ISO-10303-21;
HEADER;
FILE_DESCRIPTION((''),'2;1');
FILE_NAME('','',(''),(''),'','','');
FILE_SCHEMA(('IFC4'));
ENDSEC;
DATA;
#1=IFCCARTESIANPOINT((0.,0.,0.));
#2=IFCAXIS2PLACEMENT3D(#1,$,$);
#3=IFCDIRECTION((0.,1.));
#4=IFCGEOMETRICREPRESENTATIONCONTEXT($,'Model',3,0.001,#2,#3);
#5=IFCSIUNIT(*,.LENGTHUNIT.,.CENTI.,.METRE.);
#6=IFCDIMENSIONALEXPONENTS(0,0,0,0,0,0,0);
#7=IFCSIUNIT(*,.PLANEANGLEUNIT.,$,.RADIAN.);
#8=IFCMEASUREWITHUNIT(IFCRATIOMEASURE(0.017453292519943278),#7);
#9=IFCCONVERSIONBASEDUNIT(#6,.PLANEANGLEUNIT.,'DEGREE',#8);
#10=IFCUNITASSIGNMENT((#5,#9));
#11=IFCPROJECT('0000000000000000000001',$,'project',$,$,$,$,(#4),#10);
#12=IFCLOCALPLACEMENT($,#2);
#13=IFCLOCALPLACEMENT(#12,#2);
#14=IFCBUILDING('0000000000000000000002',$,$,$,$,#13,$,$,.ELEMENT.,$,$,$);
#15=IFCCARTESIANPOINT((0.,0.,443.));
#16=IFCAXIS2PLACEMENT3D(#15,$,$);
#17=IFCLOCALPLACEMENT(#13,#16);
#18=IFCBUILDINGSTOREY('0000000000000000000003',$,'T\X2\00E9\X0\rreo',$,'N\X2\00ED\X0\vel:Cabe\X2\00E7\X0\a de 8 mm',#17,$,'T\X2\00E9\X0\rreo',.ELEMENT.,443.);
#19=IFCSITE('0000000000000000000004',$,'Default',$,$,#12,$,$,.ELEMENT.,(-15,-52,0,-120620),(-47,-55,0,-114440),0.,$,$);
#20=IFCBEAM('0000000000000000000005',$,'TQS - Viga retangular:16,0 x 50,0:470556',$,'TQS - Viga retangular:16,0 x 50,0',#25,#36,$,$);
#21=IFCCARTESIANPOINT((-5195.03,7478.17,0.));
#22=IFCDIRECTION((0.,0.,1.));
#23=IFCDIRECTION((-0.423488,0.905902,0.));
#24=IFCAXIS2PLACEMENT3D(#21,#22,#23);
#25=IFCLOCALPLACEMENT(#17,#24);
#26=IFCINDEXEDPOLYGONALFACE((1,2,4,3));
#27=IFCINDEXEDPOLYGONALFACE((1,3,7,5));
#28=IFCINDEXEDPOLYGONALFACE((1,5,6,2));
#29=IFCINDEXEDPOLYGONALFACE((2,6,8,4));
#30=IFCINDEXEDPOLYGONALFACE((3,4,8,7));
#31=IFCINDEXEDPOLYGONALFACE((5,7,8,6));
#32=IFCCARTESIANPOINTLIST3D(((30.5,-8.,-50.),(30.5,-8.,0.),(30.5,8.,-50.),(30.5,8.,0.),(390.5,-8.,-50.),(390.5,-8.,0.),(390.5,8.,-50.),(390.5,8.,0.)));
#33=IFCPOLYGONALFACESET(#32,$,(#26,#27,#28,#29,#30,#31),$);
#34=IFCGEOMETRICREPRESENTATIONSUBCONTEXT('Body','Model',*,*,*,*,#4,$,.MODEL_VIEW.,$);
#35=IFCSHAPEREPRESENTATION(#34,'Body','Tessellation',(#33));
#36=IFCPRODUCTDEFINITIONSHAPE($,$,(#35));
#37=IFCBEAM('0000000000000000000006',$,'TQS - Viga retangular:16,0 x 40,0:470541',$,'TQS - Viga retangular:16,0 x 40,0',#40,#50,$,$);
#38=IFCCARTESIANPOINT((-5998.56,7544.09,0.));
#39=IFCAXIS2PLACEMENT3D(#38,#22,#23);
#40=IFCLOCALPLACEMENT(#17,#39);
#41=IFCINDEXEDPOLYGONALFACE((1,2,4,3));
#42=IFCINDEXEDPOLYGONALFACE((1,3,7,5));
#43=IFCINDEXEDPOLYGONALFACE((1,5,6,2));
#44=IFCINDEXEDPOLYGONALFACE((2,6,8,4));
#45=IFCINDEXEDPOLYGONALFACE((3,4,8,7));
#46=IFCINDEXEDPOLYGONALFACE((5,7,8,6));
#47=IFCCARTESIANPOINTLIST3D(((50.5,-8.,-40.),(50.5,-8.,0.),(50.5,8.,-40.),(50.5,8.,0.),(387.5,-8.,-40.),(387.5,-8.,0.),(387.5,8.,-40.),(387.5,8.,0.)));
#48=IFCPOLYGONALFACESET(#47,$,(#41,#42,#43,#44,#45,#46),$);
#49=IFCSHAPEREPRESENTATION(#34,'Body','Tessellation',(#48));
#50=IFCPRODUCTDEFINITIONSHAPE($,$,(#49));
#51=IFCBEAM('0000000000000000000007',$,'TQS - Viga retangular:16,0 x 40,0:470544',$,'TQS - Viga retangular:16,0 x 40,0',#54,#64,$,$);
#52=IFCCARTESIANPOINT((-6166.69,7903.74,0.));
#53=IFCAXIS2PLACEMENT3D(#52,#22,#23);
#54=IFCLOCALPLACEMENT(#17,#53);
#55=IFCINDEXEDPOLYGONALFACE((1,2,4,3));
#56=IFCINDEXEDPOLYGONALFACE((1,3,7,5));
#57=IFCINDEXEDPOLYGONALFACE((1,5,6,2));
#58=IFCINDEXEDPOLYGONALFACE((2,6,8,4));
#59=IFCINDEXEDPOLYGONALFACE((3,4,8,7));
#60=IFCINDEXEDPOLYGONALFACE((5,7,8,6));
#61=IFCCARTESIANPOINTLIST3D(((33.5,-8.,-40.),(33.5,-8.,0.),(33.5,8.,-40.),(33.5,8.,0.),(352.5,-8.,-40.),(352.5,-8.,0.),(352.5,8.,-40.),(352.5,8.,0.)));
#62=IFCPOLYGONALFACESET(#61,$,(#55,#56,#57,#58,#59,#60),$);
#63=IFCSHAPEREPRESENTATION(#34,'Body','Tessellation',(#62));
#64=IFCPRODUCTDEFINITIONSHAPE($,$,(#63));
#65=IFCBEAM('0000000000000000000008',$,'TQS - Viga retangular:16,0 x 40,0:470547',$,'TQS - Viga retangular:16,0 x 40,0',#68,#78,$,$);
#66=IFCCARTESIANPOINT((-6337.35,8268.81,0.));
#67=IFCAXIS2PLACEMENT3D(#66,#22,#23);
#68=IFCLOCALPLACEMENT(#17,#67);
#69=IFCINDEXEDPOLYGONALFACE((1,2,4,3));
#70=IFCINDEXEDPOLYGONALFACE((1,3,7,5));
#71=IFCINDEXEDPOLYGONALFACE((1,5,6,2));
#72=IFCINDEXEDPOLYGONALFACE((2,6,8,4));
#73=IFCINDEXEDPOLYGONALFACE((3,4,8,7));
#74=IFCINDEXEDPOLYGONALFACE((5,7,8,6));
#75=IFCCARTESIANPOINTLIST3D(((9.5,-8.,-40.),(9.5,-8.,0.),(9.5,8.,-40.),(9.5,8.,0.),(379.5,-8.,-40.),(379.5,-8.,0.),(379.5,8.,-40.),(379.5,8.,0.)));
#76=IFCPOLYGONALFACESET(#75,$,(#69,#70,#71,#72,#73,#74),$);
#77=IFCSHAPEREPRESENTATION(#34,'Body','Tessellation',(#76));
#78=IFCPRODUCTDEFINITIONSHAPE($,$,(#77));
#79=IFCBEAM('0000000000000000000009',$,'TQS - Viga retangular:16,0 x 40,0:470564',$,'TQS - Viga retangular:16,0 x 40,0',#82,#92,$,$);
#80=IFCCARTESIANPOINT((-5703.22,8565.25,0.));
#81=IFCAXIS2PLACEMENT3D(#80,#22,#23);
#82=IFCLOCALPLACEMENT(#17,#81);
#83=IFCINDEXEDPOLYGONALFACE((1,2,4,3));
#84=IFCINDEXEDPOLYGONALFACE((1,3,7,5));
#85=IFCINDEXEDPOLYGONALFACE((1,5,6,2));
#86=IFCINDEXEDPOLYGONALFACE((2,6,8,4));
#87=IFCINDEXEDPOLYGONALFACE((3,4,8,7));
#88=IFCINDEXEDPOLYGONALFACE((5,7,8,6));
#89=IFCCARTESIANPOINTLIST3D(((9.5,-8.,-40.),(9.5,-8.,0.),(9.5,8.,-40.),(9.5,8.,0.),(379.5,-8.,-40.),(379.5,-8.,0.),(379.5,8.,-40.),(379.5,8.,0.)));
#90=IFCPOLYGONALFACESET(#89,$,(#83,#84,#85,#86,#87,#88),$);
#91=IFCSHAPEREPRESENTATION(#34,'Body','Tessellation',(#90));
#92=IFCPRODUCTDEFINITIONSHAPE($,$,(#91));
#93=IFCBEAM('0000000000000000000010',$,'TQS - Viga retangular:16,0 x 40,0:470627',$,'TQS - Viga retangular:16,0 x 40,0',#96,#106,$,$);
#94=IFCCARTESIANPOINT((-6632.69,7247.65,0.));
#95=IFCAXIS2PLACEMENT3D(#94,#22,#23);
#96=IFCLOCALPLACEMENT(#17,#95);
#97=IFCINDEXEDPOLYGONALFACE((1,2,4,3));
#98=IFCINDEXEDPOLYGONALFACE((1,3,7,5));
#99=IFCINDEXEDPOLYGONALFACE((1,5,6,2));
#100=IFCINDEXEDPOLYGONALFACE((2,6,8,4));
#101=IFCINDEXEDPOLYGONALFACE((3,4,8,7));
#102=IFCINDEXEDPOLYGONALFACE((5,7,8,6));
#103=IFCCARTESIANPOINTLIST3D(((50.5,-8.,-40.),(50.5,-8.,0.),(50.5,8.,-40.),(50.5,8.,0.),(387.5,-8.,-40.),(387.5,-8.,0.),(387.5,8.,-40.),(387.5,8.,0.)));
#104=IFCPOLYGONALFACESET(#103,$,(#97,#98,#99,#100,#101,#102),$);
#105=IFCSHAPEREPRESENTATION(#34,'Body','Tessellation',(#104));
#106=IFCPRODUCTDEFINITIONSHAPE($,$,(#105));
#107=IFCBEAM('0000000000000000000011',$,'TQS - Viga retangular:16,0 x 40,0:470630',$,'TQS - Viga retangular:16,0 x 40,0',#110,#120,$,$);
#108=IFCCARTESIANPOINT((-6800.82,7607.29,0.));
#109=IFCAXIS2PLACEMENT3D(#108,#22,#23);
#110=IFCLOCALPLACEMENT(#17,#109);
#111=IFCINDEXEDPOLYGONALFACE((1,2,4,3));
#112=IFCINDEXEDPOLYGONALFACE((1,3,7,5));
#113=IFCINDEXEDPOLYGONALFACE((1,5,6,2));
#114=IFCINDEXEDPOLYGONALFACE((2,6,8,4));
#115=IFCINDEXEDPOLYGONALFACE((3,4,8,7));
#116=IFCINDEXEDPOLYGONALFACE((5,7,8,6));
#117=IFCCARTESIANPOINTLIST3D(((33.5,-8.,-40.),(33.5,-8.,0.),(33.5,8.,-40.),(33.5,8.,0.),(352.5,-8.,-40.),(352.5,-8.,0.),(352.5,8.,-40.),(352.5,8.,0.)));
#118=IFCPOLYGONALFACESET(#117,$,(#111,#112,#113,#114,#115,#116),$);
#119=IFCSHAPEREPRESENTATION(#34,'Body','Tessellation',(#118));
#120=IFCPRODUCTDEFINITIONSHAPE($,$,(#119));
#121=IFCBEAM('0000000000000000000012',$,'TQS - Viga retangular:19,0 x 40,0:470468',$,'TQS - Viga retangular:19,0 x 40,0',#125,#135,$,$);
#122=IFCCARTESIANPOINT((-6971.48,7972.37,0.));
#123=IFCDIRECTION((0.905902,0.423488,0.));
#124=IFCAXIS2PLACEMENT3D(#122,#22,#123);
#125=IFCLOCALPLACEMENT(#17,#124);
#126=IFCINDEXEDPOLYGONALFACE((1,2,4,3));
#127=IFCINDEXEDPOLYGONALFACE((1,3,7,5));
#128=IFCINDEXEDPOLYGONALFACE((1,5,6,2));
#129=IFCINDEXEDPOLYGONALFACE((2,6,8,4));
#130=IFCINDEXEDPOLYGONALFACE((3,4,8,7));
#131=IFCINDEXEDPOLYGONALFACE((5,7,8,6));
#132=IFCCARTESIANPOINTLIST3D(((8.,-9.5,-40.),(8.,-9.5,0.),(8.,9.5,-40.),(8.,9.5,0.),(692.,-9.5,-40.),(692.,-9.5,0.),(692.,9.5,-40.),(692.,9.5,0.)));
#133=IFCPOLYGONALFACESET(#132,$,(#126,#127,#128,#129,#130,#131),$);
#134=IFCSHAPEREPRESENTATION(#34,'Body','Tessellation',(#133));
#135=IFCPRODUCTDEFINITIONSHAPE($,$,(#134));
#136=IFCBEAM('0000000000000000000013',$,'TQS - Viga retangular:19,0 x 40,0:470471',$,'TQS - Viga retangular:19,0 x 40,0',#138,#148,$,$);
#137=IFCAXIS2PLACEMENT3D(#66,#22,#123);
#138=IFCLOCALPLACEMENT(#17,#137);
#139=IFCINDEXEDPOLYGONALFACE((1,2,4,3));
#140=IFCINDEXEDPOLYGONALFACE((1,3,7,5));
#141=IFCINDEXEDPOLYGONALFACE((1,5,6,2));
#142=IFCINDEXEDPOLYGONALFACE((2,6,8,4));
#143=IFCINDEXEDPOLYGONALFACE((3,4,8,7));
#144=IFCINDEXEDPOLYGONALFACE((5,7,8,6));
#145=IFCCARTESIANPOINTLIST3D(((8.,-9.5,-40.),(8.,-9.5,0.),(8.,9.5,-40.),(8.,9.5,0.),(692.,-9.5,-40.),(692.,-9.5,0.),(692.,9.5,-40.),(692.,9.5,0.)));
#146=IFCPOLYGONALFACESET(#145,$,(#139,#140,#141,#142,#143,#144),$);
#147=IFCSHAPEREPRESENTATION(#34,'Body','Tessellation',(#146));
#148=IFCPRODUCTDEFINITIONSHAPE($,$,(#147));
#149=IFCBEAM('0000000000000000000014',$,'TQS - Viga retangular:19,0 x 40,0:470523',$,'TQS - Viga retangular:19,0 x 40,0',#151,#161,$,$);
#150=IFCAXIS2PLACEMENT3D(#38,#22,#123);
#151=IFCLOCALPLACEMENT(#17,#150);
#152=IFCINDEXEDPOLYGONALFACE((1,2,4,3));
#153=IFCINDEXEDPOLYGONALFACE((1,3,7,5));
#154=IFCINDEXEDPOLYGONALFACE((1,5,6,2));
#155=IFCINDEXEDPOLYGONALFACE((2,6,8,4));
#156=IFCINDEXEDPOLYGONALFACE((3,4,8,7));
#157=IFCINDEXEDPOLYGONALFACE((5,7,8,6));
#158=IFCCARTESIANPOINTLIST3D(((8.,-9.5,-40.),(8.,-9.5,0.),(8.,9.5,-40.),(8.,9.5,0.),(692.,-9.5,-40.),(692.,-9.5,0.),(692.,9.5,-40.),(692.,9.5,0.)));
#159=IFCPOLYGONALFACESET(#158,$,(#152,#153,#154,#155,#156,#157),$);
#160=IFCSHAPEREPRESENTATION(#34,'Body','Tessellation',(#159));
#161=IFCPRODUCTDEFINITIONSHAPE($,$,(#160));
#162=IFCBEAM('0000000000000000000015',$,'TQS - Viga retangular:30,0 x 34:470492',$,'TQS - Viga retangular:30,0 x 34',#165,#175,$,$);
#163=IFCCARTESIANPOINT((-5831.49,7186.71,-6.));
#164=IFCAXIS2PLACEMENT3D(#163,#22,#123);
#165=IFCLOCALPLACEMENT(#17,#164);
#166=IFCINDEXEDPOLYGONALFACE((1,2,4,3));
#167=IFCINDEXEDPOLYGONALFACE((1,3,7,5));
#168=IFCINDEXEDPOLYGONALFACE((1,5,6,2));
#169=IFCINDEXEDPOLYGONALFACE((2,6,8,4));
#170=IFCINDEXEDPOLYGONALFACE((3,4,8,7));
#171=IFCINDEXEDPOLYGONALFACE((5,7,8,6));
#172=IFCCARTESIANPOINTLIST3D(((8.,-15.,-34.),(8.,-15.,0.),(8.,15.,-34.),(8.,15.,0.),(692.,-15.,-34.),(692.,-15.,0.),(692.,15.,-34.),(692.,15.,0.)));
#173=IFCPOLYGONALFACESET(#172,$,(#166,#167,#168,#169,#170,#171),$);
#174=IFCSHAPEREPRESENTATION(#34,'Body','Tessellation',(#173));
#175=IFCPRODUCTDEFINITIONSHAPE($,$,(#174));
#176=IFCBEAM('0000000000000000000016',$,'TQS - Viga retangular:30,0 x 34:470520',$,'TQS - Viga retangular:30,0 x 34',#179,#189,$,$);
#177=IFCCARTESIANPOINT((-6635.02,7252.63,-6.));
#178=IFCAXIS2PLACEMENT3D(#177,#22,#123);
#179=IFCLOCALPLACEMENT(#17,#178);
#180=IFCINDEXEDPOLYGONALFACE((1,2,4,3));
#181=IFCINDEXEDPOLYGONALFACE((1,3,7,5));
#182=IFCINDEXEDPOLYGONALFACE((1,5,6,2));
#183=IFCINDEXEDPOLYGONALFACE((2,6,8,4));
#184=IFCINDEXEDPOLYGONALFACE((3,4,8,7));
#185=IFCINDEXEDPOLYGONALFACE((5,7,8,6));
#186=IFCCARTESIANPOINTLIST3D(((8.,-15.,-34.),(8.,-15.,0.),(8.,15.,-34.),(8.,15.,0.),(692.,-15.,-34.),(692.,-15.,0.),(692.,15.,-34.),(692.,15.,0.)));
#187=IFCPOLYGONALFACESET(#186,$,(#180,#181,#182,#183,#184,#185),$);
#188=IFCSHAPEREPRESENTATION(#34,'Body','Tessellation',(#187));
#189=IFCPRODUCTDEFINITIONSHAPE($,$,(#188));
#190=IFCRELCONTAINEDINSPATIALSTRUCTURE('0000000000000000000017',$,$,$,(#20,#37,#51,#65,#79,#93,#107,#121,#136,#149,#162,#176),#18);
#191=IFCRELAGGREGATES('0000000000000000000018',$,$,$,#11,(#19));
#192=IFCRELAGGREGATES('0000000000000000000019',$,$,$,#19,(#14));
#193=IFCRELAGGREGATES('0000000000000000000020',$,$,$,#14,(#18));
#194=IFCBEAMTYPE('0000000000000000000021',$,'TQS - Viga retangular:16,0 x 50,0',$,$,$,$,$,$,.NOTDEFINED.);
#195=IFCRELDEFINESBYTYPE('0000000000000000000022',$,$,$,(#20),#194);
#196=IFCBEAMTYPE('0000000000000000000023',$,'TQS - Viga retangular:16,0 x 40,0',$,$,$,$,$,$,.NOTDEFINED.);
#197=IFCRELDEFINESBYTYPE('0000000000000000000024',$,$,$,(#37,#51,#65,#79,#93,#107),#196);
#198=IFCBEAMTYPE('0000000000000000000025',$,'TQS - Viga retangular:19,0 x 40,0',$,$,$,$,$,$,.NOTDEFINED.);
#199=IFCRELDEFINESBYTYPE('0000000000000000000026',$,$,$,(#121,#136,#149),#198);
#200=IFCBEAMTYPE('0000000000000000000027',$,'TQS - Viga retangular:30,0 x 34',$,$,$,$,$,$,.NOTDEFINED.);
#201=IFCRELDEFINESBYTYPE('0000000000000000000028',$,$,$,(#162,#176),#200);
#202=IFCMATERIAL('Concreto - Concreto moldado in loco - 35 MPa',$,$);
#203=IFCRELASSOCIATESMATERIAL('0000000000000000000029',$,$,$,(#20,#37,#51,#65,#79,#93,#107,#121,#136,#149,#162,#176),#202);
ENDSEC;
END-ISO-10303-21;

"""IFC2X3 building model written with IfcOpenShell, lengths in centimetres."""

from ifc_helpers import new_model, entity, si_unit, converted_unit, direction, frame, frame_2d, origin, origin_2d_with_axis, place, context, subcontext, project, spatial, rectangle, extrude, material, type_object, element, save


model = new_model("IFC2X3")

# Units and contexts
model_context = context("Model", 3, precision=0.001, world=origin(), true_north=direction((0.0, 1.0)))
body_context = subcontext(model_context, "Body", "Model", "MODEL_VIEW")
ifc_project = project(units=[si_unit("LENGTHUNIT", "METRE", prefix="CENTI"), converted_unit("PLANEANGLEUNIT", "DEGREE", entity("IfcRatioMeasure", 0.017453292519943278), si_unit("PLANEANGLEUNIT", "RADIAN"), dimensions=[0, 0, 0, 0, 0, 0, 0])], contexts=[model_context])

# Site, building, storey
site_placement = place(None, origin())
site = spatial("IfcSite", under=ifc_project, at=site_placement, Name="Default", CompositionType="ELEMENT", RefLatitude=(-15, -52, 0, -120620), RefLongitude=(-47, -55, 0, -114440), RefElevation=0.0)
building_placement = place(site_placement, origin())
building = spatial("IfcBuilding", under=site, at=building_placement, CompositionType="ELEMENT")
storey_placement = place(building_placement, frame((0.0, 0.0, 443.0)))
storey = spatial("IfcBuildingStorey", under=building, at=storey_placement, Name="Térreo", ObjectType="Nível:Cabeça de 8 mm", LongName="Térreo", CompositionType="ELEMENT", Elevation=443.0)

# Shared definitions
ifc_material_1 = material(Name="Concreto - Concreto moldado in loco - 35 MPa")

# Beams
beam_type_1 = type_object("IfcBeamType", Name="TQS - Viga retangular:16,0 x 50,0", PredefinedType="NOTDEFINED")
beam_1_placement = place(storey_placement, frame((-5195.03, 7478.17, 0.0), z_axis=(0.0, 0.0, 1.0), x_axis=(-0.423488, 0.905902, 0.0)))
element("IfcBeam", 1, at=beam_1_placement, inside=storey, type_object=beam_type_1, material=ifc_material_1, Name="TQS - Viga retangular:16,0 x 50,0:470556", ObjectType="TQS - Viga retangular:16,0 x 50,0", context=body_context, shape_type="SweptSolid", body=[
    extrude(rectangle(XDim=50.0, YDim=16.0, at=frame_2d((0.0, 0.0), x_axis=(1.0, 0.0))), frame((30.5, 0.0, -25.0), z_axis=(1.0, 0.0, 0.0), x_axis=(0.0, 0.0, -1.0)), (0.0, 0.0, 1.0), 360.0),
])
beam_type_2 = type_object("IfcBeamType", Name="TQS - Viga retangular:16,0 x 40,0", PredefinedType="NOTDEFINED")
beam_2_placement = place(storey_placement, frame((-5998.56, 7544.09, 0.0), z_axis=(0.0, 0.0, 1.0), x_axis=(-0.423488, 0.905902, 0.0)))
element("IfcBeam", 2, at=beam_2_placement, inside=storey, type_object=beam_type_2, material=ifc_material_1, Name="TQS - Viga retangular:16,0 x 40,0:470541", ObjectType="TQS - Viga retangular:16,0 x 40,0", context=body_context, shape_type="SweptSolid", body=[
    extrude(rectangle(XDim=40.0, YDim=16.0, at=frame_2d((0.0, 0.0), x_axis=(1.0, 0.0))), frame((50.5, 0.0, -20.0), z_axis=(1.0, 0.0, 0.0), x_axis=(0.0, 0.0, -1.0)), (0.0, 0.0, 1.0), 337.0),
])
beam_3_placement = place(storey_placement, frame((-6166.69, 7903.74, 0.0), z_axis=(0.0, 0.0, 1.0), x_axis=(-0.423488, 0.905902, 0.0)))
element("IfcBeam", 3, at=beam_3_placement, inside=storey, type_object=beam_type_2, material=ifc_material_1, Name="TQS - Viga retangular:16,0 x 40,0:470544", ObjectType="TQS - Viga retangular:16,0 x 40,0", context=body_context, shape_type="SweptSolid", body=[
    extrude(rectangle(XDim=40.0, YDim=16.0, at=origin_2d_with_axis()), frame((33.5, 0.0, -20.0), z_axis=(1.0, 0.0, 0.0), x_axis=(0.0, 0.0, -1.0)), (0.0, 0.0, 1.0), 319.0),
])
beam_4_placement = place(storey_placement, frame((-6337.35, 8268.81, 0.0), z_axis=(0.0, 0.0, 1.0), x_axis=(-0.423488, 0.905902, 0.0)))
element("IfcBeam", 4, at=beam_4_placement, inside=storey, type_object=beam_type_2, material=ifc_material_1, Name="TQS - Viga retangular:16,0 x 40,0:470547", ObjectType="TQS - Viga retangular:16,0 x 40,0", context=body_context, shape_type="SweptSolid", body=[
    extrude(rectangle(XDim=40.0, YDim=16.0, at=frame_2d((0.0, 0.0), x_axis=(1.0, 0.0))), frame((9.5, 0.0, -20.0), z_axis=(1.0, 0.0, 0.0), x_axis=(0.0, 0.0, -1.0)), (0.0, 0.0, 1.0), 370.0),
])
beam_5_placement = place(storey_placement, frame((-5703.22, 8565.25, 0.0), z_axis=(0.0, 0.0, 1.0), x_axis=(-0.423488, 0.905902, 0.0)))
element("IfcBeam", 5, at=beam_5_placement, inside=storey, type_object=beam_type_2, material=ifc_material_1, Name="TQS - Viga retangular:16,0 x 40,0:470564", ObjectType="TQS - Viga retangular:16,0 x 40,0", context=body_context, shape_type="SweptSolid", body=[
    extrude(rectangle(XDim=40.0, YDim=16.0, at=frame_2d((0.0, 0.0), x_axis=(1.0, 0.0))), frame((9.5, 0.0, -20.0), z_axis=(1.0, 0.0, 0.0), x_axis=(0.0, 0.0, -1.0)), (0.0, 0.0, 1.0), 370.0),
])
beam_6_placement = place(storey_placement, frame((-6632.69, 7247.65, 0.0), z_axis=(0.0, 0.0, 1.0), x_axis=(-0.423488, 0.905902, 0.0)))
element("IfcBeam", 6, at=beam_6_placement, inside=storey, type_object=beam_type_2, material=ifc_material_1, Name="TQS - Viga retangular:16,0 x 40,0:470627", ObjectType="TQS - Viga retangular:16,0 x 40,0", context=body_context, shape_type="SweptSolid", body=[
    extrude(rectangle(XDim=40.0, YDim=16.0, at=frame_2d((0.0, 0.0), x_axis=(1.0, 0.0))), frame((50.5, 0.0, -20.0), z_axis=(1.0, 0.0, 0.0), x_axis=(0.0, 0.0, -1.0)), (0.0, 0.0, 1.0), 337.0),
])
beam_7_placement = place(storey_placement, frame((-6800.82, 7607.29, 0.0), z_axis=(0.0, 0.0, 1.0), x_axis=(-0.423488, 0.905902, 0.0)))
element("IfcBeam", 7, at=beam_7_placement, inside=storey, type_object=beam_type_2, material=ifc_material_1, Name="TQS - Viga retangular:16,0 x 40,0:470630", ObjectType="TQS - Viga retangular:16,0 x 40,0", context=body_context, shape_type="SweptSolid", body=[
    extrude(rectangle(XDim=40.0, YDim=16.0, at=frame_2d((0.0, 0.0), x_axis=(1.0, 0.0))), frame((33.5, 0.0, -20.0), z_axis=(1.0, 0.0, 0.0), x_axis=(0.0, 0.0, -1.0)), (0.0, 0.0, 1.0), 319.0),
])
beam_type_3 = type_object("IfcBeamType", Name="TQS - Viga retangular:19,0 x 40,0", PredefinedType="NOTDEFINED")
beam_8_placement = place(storey_placement, frame((-6971.48, 7972.37, 0.0), z_axis=(0.0, 0.0, 1.0), x_axis=(0.905902, 0.423488, 0.0)))
element("IfcBeam", 8, at=beam_8_placement, inside=storey, type_object=beam_type_3, material=ifc_material_1, Name="TQS - Viga retangular:19,0 x 40,0:470468", ObjectType="TQS - Viga retangular:19,0 x 40,0", context=body_context, shape_type="SweptSolid", body=[
    extrude(rectangle(XDim=40.0, YDim=19.0, at=frame_2d((0.0, 0.0), x_axis=(1.0, 0.0))), frame((8.0, 0.0, -20.0), z_axis=(1.0, 0.0, 0.0), x_axis=(0.0, 0.0, -1.0)), (0.0, 0.0, 1.0), 684.0),
])
beam_9_placement = place(storey_placement, frame((-6337.35, 8268.81, 0.0), z_axis=(0.0, 0.0, 1.0), x_axis=(0.905902, 0.423488, 0.0)))
element("IfcBeam", 9, at=beam_9_placement, inside=storey, type_object=beam_type_3, material=ifc_material_1, Name="TQS - Viga retangular:19,0 x 40,0:470471", ObjectType="TQS - Viga retangular:19,0 x 40,0", context=body_context, shape_type="SweptSolid", body=[
    extrude(rectangle(XDim=40.0, YDim=19.0, at=frame_2d((0.0, 0.0), x_axis=(1.0, 0.0))), frame((8.0, 0.0, -20.0), z_axis=(1.0, 0.0, 0.0), x_axis=(0.0, 0.0, -1.0)), (0.0, 0.0, 1.0), 684.0),
])
beam_10_placement = place(storey_placement, frame((-5998.56, 7544.09, 0.0), z_axis=(0.0, 0.0, 1.0), x_axis=(0.905902, 0.423488, 0.0)))
element("IfcBeam", 10, at=beam_10_placement, inside=storey, type_object=beam_type_3, material=ifc_material_1, Name="TQS - Viga retangular:19,0 x 40,0:470523", ObjectType="TQS - Viga retangular:19,0 x 40,0", context=body_context, shape_type="SweptSolid", body=[
    extrude(rectangle(XDim=40.0, YDim=19.0, at=origin_2d_with_axis()), frame((8.0, 0.0, -20.0), z_axis=(1.0, 0.0, 0.0), x_axis=(0.0, 0.0, -1.0)), (0.0, 0.0, 1.0), 684.0),
])
beam_type_4 = type_object("IfcBeamType", Name="TQS - Viga retangular:30,0 x 34", PredefinedType="NOTDEFINED")
beam_11_placement = place(storey_placement, frame((-5831.49, 7186.71, -6.0), z_axis=(0.0, 0.0, 1.0), x_axis=(0.905902, 0.423488, 0.0)))
element("IfcBeam", 11, at=beam_11_placement, inside=storey, type_object=beam_type_4, material=ifc_material_1, Name="TQS - Viga retangular:30,0 x 34:470492", ObjectType="TQS - Viga retangular:30,0 x 34", context=body_context, shape_type="SweptSolid", body=[
    extrude(rectangle(XDim=34.0, YDim=30.0, at=frame_2d((0.0, 0.0), x_axis=(1.0, 0.0))), frame((8.0, 0.0, -17.0), z_axis=(1.0, 0.0, 0.0), x_axis=(0.0, 0.0, -1.0)), (0.0, 0.0, 1.0), 684.0),
])
beam_12_placement = place(storey_placement, frame((-6635.02, 7252.63, -6.0), z_axis=(0.0, 0.0, 1.0), x_axis=(0.905902, 0.423488, 0.0)))
element("IfcBeam", 12, at=beam_12_placement, inside=storey, type_object=beam_type_4, material=ifc_material_1, Name="TQS - Viga retangular:30,0 x 34:470520", ObjectType="TQS - Viga retangular:30,0 x 34", context=body_context, shape_type="SweptSolid", body=[
    extrude(rectangle(XDim=34.0, YDim=30.0, at=frame_2d((0.0, 0.0), x_axis=(1.0, 0.0))), frame((8.0, 0.0, -17.0), z_axis=(1.0, 0.0, 0.0), x_axis=(0.0, 0.0, -1.0)), (0.0, 0.0, 1.0), 684.0),
])

save(model, "model.ifc")
